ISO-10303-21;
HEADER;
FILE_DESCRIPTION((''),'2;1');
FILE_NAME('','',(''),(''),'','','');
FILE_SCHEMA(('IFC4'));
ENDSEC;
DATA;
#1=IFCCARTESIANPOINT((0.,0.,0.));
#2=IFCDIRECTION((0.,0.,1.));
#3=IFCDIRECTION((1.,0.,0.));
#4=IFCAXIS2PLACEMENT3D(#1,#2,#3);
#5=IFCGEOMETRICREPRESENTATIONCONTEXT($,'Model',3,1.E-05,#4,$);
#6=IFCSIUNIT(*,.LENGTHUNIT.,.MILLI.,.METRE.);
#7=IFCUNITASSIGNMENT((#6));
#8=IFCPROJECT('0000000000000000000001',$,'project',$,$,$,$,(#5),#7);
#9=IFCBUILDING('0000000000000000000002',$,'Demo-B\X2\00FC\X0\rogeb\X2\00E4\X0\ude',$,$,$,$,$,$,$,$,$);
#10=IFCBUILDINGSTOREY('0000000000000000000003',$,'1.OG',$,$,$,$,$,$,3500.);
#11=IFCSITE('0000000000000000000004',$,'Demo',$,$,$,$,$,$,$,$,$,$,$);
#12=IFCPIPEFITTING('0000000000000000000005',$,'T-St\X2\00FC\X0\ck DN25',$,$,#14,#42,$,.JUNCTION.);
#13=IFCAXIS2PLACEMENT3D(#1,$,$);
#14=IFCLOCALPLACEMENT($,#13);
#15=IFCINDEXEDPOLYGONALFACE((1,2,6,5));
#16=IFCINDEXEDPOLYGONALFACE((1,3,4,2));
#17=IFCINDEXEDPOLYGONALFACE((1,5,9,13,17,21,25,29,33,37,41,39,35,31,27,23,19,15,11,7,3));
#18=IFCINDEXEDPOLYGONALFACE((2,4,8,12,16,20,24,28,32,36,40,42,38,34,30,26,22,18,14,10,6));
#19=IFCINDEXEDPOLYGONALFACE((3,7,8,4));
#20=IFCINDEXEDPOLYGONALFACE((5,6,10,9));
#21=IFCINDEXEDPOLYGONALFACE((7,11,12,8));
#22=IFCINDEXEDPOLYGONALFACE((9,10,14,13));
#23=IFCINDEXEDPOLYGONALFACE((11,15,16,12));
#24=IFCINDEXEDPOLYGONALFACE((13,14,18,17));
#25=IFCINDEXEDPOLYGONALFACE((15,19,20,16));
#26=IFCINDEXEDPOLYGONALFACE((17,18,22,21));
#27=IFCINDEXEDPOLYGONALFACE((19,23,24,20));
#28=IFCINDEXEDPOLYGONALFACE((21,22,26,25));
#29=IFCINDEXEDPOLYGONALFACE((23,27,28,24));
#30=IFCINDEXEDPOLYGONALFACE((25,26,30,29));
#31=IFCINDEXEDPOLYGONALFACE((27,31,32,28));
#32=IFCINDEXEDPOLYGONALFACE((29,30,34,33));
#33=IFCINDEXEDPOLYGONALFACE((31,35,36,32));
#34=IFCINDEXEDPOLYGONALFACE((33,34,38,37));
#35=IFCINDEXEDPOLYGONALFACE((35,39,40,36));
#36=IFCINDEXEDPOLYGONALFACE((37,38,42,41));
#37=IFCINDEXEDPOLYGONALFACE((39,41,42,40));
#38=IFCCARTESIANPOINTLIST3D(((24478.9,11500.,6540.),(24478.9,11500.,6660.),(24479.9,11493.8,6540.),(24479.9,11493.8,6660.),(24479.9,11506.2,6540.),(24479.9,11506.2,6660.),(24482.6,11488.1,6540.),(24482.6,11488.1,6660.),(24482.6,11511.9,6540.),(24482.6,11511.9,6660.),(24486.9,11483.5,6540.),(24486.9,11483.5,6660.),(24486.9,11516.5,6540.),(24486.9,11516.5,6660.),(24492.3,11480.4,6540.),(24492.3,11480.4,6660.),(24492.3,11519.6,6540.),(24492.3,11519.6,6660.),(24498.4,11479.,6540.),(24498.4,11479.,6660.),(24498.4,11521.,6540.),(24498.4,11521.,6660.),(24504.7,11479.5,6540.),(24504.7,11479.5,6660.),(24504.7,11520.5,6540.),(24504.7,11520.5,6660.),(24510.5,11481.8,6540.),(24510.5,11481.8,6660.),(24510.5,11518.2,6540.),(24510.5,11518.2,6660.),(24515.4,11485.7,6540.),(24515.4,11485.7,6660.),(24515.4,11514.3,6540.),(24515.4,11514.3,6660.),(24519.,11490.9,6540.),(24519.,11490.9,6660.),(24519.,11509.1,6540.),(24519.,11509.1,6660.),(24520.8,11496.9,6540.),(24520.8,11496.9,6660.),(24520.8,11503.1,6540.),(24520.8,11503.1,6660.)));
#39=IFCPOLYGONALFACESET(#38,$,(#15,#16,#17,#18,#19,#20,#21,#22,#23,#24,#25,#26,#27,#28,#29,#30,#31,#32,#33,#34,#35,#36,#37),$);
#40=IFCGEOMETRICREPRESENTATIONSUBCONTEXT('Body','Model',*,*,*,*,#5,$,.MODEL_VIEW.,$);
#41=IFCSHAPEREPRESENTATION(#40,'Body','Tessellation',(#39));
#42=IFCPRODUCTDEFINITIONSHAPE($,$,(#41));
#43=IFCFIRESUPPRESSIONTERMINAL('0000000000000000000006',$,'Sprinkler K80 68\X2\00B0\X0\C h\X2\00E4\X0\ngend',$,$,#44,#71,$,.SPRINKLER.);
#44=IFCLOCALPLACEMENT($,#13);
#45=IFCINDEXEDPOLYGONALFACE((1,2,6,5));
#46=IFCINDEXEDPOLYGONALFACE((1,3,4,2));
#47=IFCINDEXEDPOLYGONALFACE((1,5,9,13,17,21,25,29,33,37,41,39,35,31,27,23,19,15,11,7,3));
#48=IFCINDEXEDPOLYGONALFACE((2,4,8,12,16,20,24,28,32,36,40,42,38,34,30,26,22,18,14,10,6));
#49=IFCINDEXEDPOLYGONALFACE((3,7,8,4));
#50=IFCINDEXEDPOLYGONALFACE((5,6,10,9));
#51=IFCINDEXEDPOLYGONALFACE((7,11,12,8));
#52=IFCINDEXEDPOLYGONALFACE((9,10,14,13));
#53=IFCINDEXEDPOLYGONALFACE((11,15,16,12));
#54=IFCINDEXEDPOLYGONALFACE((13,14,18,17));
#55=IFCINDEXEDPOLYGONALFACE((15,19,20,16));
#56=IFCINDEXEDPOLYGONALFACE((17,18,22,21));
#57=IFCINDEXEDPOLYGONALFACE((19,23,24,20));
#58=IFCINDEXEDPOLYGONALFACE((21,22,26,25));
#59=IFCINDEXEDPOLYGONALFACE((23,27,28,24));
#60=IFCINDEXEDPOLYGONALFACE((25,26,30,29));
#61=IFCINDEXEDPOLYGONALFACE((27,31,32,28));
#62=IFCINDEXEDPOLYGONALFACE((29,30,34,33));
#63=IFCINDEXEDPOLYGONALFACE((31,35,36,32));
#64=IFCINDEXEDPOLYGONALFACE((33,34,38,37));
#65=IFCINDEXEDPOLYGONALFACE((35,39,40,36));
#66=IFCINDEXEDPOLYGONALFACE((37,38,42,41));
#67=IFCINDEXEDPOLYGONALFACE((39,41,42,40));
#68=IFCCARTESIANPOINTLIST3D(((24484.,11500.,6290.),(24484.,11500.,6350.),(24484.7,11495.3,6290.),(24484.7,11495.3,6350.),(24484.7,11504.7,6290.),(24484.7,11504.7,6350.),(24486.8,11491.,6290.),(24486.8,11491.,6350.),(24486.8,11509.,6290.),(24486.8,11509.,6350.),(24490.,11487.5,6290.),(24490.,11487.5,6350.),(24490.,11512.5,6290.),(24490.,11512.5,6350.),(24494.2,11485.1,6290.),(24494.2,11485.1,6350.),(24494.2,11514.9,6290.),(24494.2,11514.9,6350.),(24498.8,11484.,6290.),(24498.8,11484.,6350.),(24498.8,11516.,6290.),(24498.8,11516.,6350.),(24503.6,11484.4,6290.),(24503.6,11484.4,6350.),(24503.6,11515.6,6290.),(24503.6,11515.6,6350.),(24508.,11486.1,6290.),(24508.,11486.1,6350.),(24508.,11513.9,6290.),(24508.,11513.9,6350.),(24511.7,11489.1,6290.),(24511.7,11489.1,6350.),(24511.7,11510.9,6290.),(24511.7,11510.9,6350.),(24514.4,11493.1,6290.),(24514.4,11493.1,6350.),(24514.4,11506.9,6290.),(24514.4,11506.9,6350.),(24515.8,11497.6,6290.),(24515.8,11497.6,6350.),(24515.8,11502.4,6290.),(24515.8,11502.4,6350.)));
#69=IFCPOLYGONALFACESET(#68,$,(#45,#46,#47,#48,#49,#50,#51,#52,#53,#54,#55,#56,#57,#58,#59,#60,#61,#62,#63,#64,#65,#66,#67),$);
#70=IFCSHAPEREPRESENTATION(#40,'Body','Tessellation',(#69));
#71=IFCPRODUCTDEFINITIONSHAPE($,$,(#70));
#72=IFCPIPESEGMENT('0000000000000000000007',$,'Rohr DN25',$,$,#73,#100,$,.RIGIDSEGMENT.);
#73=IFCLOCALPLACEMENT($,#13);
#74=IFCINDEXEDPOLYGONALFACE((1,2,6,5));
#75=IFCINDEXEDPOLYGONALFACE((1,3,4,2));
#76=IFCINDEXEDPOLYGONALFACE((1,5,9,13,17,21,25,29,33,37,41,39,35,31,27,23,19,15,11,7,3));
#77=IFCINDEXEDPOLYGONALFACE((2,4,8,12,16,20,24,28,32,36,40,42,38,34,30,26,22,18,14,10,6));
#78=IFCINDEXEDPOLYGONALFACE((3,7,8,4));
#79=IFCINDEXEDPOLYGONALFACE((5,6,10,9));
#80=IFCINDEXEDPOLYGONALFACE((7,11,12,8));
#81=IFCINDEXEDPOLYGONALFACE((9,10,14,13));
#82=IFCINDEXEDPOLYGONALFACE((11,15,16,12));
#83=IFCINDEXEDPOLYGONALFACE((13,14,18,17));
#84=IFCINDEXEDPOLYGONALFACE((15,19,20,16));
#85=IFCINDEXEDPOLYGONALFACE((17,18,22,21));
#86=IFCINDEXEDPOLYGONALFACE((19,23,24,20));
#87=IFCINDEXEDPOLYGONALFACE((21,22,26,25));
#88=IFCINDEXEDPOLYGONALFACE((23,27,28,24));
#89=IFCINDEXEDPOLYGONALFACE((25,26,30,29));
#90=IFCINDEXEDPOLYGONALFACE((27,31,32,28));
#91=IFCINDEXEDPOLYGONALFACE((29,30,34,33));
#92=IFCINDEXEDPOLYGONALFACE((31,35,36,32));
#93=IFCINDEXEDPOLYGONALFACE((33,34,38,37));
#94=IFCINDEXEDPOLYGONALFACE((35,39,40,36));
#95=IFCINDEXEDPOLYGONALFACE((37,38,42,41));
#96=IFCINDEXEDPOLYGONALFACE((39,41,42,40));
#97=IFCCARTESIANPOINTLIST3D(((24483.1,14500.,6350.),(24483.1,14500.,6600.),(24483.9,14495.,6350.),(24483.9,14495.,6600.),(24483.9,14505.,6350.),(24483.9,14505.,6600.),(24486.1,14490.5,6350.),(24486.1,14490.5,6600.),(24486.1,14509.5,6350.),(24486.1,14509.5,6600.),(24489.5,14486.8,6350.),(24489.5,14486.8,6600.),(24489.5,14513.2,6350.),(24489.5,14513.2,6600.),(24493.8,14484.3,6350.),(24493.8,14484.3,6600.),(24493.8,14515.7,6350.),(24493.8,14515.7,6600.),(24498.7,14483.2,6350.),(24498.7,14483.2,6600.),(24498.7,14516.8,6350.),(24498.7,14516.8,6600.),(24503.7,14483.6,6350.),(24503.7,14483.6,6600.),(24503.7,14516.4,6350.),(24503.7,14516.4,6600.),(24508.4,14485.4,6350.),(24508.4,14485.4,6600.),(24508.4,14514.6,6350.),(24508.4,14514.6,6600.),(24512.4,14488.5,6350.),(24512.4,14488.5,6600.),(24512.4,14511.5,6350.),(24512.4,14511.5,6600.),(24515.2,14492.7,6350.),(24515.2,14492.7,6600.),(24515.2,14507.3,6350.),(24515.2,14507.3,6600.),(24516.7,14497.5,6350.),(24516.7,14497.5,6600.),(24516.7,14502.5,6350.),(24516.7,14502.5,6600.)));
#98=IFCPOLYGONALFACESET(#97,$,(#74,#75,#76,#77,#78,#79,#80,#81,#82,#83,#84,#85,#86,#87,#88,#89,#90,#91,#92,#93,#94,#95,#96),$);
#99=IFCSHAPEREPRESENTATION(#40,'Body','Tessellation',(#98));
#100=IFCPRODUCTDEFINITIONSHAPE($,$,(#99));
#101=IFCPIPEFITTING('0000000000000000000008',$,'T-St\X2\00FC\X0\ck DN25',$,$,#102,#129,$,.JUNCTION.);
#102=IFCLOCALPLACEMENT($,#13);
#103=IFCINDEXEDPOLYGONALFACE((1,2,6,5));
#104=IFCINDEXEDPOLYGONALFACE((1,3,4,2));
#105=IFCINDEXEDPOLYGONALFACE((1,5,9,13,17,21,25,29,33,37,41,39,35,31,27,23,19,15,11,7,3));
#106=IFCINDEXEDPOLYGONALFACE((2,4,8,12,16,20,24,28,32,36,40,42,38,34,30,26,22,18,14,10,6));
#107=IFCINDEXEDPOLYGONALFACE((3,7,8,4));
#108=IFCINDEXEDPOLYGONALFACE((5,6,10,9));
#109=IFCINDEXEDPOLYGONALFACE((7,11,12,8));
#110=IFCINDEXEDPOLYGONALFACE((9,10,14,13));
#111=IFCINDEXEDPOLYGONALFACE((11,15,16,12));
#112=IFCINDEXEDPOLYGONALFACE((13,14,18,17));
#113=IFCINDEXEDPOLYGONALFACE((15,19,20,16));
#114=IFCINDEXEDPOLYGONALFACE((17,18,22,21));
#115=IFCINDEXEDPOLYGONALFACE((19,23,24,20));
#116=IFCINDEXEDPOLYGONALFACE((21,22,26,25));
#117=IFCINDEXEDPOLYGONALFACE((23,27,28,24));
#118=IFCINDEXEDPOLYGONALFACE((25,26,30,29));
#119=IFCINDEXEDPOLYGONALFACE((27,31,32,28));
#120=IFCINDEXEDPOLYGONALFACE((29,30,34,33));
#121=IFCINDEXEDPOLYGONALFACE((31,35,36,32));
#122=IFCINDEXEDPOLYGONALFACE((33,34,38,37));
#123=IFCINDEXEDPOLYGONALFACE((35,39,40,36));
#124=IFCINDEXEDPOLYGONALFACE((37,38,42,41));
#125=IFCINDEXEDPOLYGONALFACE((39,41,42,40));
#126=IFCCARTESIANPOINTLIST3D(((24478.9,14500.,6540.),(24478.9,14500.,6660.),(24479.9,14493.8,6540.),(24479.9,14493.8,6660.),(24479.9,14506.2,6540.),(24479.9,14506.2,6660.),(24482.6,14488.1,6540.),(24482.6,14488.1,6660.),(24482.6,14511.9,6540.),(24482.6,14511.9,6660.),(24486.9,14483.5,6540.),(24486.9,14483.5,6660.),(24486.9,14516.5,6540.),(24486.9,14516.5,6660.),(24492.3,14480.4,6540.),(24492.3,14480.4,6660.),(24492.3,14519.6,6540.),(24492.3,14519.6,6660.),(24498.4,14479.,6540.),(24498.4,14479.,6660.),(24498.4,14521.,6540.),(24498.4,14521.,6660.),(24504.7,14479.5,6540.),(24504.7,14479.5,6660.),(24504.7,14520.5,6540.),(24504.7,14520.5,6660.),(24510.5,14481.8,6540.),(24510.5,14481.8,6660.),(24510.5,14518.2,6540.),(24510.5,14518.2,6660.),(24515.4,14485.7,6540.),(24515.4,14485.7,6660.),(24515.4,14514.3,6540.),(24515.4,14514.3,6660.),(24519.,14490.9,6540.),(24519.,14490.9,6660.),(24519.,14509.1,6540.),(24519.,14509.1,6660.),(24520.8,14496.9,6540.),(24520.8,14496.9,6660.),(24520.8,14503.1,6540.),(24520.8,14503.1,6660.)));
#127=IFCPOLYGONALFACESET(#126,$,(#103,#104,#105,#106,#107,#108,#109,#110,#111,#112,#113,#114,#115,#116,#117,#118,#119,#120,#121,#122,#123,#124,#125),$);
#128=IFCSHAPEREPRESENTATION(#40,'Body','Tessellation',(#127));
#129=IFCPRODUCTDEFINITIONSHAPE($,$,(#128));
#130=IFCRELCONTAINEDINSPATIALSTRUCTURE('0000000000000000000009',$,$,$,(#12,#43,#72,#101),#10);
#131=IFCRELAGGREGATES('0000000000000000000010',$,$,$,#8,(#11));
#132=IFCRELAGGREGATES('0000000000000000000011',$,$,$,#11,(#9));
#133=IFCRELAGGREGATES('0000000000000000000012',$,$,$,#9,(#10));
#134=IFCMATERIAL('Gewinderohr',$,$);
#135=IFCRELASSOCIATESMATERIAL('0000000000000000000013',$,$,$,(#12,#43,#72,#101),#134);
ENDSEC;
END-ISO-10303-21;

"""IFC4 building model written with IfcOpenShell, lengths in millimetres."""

from ifc_helpers import new_model, si_unit, frame, origin_with_axes, place, context, subcontext, project, spatial, circle, extrude, material, element, save


model = new_model("IFC4")

# Units and contexts
model_context = context("Model", 3, precision=1e-05, world=origin_with_axes())
body_context = subcontext(model_context, "Body", "Model", "MODEL_VIEW")
ifc_project = project(units=[si_unit("LENGTHUNIT", "METRE", prefix="MILLI")], contexts=[model_context])

# Site, building, storey
site = spatial("IfcSite", under=ifc_project, Name="Demo")
building = spatial("IfcBuilding", under=site, Name="Demo-Bürogebäude")
storey = spatial("IfcBuildingStorey", under=building, Name="1.OG", Elevation=3500.0)

# Shared definitions
ifc_material_1 = material(Name="Gewinderohr")

# Pipe fitting
pipe_fitting_1_placement = place(None, frame((24500.0, 11500.0, 6660.0), z_axis=(0.0, 0.0, -1.0), x_axis=(-1.0, 0.0, 0.0)))
element("IfcPipeFitting", 1, at=pipe_fitting_1_placement, inside=storey, material=ifc_material_1, Name="T-Stück DN25", PredefinedType="JUNCTION", context=body_context, shape_type="SweptSolid", body=[
    extrude(circle(Radius=21.1), origin_with_axes(), (0.0, 0.0, 1.0), 120.0),
])

# Fire suppression terminal
fire_suppression_terminal_1_placement = place(None, frame((24500.0, 11500.0, 6350.0), z_axis=(0.0, 0.0, -1.0), x_axis=(-1.0, 0.0, 0.0)))
element("IfcFireSuppressionTerminal", 2, at=fire_suppression_terminal_1_placement, inside=storey, material=ifc_material_1, Name="Sprinkler K80 68°C hängend", PredefinedType="SPRINKLER", context=body_context, shape_type="SweptSolid", body=[
    extrude(circle(Radius=16.0), origin_with_axes(), (0.0, 0.0, 1.0), 60.0),
])

# Pipe segment
pipe_segment_1_placement = place(None, frame((24500.0, 14500.0, 6600.0), z_axis=(0.0, 0.0, -1.0), x_axis=(-1.0, 0.0, 0.0)))
element("IfcPipeSegment", 3, at=pipe_segment_1_placement, inside=storey, material=ifc_material_1, Name="Rohr DN25", PredefinedType="RIGIDSEGMENT", context=body_context, shape_type="SweptSolid", body=[
    extrude(circle(Radius=16.9), origin_with_axes(), (0.0, 0.0, 1.0), 250.0),
])

# Pipe fitting
pipe_fitting_2_placement = place(None, frame((24500.0, 14500.0, 6660.0), z_axis=(0.0, 0.0, -1.0), x_axis=(-1.0, 0.0, 0.0)))
element("IfcPipeFitting", 4, at=pipe_fitting_2_placement, inside=storey, material=ifc_material_1, Name="T-Stück DN25", PredefinedType="JUNCTION", context=body_context, shape_type="SweptSolid", body=[
    extrude(circle(Radius=21.1), origin_with_axes(), (0.0, 0.0, 1.0), 120.0),
])

save(model, "model.ifc")
